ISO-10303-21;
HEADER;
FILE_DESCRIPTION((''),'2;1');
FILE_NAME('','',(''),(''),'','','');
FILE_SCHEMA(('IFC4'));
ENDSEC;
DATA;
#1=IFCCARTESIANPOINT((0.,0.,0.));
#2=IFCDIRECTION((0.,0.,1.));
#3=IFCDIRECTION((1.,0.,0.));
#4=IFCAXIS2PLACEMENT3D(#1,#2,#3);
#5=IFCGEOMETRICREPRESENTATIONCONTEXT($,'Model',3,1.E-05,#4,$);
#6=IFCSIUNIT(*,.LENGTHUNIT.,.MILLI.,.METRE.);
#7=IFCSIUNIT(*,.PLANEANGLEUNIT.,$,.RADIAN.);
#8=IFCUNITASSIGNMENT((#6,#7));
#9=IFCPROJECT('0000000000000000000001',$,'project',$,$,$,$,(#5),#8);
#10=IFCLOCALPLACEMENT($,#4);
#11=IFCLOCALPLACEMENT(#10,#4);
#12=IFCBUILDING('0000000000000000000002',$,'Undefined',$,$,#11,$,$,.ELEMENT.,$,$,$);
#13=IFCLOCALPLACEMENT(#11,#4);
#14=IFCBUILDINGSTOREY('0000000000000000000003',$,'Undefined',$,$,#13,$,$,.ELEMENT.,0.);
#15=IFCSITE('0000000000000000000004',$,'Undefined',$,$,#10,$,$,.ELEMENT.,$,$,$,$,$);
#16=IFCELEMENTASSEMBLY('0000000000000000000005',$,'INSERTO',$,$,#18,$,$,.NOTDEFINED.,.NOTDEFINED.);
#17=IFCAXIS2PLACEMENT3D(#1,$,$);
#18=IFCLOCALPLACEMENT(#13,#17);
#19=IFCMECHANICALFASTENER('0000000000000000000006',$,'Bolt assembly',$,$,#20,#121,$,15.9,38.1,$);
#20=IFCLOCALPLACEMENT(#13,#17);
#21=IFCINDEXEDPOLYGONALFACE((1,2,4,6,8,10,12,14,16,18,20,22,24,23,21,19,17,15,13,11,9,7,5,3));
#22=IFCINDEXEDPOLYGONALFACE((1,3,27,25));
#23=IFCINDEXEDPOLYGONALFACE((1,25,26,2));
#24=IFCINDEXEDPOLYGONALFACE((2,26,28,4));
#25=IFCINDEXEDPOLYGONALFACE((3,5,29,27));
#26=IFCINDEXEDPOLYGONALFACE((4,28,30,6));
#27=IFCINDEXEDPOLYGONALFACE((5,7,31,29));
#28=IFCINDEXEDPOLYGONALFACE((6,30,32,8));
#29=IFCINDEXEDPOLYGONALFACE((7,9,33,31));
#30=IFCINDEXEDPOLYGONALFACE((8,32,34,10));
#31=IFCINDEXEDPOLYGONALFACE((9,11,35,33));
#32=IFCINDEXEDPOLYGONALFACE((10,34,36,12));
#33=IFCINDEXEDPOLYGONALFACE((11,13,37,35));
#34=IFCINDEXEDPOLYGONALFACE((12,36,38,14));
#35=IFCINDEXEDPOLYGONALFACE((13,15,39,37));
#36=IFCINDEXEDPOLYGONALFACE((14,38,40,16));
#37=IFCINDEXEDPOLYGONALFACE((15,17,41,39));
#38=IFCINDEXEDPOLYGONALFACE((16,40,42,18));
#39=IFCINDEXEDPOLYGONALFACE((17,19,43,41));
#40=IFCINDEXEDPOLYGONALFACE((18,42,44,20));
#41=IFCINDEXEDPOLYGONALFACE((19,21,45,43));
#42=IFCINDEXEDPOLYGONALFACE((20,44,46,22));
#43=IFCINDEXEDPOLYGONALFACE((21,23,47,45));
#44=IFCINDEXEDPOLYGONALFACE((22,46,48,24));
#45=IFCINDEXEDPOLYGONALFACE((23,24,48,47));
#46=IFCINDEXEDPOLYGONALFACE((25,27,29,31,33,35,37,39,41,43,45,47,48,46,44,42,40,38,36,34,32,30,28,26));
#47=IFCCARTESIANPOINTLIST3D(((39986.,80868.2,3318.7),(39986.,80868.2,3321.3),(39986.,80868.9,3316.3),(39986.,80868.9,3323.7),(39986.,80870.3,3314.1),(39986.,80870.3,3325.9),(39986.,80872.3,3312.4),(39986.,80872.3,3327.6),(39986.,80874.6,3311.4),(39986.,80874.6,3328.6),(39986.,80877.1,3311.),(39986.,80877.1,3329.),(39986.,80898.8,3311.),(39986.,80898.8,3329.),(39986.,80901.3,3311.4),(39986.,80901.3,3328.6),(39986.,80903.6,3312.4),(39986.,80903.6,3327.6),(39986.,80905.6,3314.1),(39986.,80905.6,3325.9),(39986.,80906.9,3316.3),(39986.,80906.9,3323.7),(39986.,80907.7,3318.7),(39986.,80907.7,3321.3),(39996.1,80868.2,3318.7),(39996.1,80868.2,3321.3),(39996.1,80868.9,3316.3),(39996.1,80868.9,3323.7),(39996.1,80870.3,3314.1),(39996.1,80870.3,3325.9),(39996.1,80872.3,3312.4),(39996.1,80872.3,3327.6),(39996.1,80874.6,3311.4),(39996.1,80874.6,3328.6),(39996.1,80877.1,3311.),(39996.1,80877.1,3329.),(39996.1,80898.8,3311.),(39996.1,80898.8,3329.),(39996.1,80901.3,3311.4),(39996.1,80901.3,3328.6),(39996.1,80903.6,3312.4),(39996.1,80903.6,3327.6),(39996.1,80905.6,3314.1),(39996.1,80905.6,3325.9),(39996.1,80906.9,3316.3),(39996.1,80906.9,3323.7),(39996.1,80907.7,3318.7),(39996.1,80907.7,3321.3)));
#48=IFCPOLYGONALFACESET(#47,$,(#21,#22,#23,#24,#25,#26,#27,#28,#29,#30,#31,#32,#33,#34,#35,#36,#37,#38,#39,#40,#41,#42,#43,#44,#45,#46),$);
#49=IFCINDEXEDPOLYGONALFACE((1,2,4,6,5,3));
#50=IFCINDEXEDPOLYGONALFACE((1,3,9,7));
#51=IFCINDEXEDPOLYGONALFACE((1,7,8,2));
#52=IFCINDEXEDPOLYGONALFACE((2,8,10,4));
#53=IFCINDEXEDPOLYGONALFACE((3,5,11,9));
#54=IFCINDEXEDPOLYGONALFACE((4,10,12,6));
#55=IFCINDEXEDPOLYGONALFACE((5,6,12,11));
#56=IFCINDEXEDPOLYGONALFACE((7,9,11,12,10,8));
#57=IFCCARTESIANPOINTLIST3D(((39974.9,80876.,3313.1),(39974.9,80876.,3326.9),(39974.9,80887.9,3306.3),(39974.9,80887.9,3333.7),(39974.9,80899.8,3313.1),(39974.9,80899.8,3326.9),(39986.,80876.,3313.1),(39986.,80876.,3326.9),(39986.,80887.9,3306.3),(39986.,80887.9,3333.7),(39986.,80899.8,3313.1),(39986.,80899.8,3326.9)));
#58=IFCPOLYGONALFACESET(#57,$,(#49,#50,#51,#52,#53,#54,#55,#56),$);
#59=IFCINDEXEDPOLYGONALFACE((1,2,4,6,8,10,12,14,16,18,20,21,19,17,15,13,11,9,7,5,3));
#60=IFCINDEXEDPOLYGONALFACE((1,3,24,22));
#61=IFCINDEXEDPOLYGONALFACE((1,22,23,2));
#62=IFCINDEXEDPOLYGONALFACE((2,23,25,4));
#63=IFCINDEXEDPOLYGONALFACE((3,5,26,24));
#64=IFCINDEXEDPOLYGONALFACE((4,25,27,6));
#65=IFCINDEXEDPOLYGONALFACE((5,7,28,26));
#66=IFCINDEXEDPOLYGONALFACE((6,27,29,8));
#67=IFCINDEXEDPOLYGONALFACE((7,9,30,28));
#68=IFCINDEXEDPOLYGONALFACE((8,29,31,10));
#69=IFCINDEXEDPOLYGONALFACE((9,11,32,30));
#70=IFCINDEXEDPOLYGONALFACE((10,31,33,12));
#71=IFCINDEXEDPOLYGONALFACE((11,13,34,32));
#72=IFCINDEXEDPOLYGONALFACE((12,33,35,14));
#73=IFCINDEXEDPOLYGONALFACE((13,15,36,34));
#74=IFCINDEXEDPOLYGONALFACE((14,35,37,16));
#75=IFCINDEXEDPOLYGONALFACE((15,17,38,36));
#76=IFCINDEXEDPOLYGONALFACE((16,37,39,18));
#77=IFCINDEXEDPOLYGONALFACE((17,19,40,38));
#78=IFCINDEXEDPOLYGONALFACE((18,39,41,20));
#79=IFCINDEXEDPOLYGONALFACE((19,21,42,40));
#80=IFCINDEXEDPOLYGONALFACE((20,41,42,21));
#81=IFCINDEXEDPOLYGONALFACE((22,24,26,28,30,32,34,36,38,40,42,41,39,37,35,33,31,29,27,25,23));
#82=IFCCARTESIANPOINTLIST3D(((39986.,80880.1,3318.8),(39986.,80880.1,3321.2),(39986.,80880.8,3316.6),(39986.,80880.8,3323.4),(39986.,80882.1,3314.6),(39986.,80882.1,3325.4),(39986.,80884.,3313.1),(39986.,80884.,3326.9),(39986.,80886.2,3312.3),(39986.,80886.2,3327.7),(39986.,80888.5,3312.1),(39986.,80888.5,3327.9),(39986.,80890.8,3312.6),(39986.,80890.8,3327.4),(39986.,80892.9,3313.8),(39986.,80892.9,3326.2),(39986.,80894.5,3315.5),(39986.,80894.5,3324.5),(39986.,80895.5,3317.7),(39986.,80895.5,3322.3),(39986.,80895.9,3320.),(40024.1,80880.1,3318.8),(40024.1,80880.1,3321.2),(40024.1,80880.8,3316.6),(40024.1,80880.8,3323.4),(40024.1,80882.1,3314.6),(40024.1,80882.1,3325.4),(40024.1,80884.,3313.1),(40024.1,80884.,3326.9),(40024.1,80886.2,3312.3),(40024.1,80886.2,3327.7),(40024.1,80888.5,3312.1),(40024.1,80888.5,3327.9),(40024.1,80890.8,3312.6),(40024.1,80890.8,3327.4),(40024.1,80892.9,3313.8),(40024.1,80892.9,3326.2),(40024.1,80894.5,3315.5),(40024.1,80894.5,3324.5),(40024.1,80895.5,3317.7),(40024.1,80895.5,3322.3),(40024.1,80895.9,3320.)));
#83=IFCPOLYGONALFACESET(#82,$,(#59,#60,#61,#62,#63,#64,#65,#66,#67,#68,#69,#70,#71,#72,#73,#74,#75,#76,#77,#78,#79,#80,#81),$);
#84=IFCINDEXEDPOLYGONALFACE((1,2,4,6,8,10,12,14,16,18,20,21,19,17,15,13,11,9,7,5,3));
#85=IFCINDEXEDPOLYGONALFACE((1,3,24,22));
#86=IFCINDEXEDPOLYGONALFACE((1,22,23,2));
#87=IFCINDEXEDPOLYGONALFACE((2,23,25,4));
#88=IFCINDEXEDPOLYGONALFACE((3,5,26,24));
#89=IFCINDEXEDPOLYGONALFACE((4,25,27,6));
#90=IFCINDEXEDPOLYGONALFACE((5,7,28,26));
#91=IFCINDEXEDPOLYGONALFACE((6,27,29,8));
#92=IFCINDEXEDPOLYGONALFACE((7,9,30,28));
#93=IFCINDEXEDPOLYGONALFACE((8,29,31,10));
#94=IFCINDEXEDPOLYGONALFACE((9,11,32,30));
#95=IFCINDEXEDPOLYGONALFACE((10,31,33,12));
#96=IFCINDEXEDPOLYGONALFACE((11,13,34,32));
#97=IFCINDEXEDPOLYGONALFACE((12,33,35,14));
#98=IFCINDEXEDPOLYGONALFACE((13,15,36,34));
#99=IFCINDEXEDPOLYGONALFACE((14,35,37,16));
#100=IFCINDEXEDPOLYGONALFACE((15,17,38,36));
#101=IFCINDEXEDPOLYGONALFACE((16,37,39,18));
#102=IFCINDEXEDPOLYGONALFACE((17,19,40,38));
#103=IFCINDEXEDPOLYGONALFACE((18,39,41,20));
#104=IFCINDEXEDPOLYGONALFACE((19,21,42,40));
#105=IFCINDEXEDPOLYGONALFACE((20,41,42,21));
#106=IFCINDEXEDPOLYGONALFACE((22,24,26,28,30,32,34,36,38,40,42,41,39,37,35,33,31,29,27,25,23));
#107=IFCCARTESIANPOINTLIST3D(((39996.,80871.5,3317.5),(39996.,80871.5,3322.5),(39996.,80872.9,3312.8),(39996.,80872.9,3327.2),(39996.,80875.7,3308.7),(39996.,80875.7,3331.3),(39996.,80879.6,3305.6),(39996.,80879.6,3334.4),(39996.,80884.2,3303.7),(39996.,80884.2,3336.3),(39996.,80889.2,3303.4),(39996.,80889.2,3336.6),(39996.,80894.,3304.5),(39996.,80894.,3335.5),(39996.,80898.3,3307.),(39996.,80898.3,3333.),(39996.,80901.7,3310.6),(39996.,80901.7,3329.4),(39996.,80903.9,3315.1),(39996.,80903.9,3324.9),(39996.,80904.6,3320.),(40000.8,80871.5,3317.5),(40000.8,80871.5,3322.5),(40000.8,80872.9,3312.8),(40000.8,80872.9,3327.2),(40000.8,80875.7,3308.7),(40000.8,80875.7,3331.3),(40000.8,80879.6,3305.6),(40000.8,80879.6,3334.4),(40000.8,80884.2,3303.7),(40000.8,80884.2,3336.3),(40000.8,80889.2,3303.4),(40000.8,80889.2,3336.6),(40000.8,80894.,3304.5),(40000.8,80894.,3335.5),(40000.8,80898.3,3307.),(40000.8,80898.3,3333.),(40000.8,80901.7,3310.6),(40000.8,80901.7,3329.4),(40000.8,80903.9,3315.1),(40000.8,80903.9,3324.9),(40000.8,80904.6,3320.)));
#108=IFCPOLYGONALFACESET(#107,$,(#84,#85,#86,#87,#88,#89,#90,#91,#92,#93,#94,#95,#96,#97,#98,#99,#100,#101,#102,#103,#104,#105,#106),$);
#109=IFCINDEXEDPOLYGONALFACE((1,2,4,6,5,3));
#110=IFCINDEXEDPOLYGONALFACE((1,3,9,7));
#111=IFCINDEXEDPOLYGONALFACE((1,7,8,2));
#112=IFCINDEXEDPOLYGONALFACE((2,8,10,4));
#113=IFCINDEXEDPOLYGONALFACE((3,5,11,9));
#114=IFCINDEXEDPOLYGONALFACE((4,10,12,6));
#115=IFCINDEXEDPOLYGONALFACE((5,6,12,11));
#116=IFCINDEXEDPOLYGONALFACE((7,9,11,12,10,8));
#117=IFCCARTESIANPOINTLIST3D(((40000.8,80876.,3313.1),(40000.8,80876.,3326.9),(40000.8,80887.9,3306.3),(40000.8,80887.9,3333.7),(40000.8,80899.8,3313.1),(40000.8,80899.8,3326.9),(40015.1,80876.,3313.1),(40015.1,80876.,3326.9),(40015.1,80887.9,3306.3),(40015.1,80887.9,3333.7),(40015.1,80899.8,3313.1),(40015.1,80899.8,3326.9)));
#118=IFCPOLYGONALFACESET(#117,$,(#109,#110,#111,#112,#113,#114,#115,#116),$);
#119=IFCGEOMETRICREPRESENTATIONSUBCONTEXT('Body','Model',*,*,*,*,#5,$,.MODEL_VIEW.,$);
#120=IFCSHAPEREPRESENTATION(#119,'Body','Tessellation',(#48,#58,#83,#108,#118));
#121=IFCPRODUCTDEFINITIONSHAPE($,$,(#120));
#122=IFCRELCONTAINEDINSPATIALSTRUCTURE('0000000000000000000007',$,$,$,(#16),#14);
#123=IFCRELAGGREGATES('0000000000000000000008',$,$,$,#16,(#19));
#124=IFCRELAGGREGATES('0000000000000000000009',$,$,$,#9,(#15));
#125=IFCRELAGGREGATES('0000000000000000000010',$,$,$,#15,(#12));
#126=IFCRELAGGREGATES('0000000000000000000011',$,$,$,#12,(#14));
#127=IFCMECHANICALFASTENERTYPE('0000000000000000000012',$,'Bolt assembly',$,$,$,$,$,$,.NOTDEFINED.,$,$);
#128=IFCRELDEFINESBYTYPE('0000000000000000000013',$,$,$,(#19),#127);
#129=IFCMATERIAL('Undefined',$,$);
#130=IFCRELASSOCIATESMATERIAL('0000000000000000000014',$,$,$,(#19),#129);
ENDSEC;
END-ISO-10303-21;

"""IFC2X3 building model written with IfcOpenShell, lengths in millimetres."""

from ifc_helpers import new_model, si_unit, frame, frame_2d, origin_with_axes, origin_2d_with_axis, place, context, subcontext, project, spatial, polyline, circle_curve, parameter, trimmed, segment, composite_curve, circle, outline, extrude, source, transform, mapped, material, type_object, element, aggregate, save


model = new_model("IFC2X3")

# Units and contexts
model_context = context("Model", 3, precision=1e-05, world=origin_with_axes())
body_context = subcontext(model_context, "Body", "Model", "MODEL_VIEW")
ifc_project = project(units=[si_unit("LENGTHUNIT", "METRE", prefix="MILLI"), si_unit("PLANEANGLEUNIT", "RADIAN")], contexts=[model_context])

# Site, building, storey
site_placement = place(None, origin_with_axes())
site = spatial("IfcSite", under=ifc_project, at=site_placement, Name="Undefined", CompositionType="ELEMENT")
building_placement = place(site_placement, origin_with_axes())
building = spatial("IfcBuilding", under=site, at=building_placement, Name="Undefined", CompositionType="ELEMENT")
storey_placement = place(building_placement, origin_with_axes())
storey = spatial("IfcBuildingStorey", under=building, at=storey_placement, Name="Undefined", CompositionType="ELEMENT", Elevation=0.0)

# Element assembly
assembly_1_placement = place(storey_placement, origin_with_axes())
assembly_1 = element("IfcElementAssembly", 1, at=assembly_1_placement, inside=storey, Name="INSERTO", AssemblyPlace="NOTDEFINED", PredefinedType="NOTDEFINED")

# Shared definitions
ifc_material_1 = material(Name="Undefined")
mechanical_fastener_type = type_object("IfcMechanicalFastenerType", Name="Bolt assembly")

# Mechanical fastener
shared_shape_1 = source(origin_with_axes(), body_context, "Body", "SweptSolid", [
    extrude(outline(composite_curve([segment(polyline([(-10.8, 9.0), (10.8, 9.0)]), True, "CONTINUOUS"), segment(trimmed(circle_curve(frame_2d((10.8, 0.0), x_axis=(0.0, 1.0)), 9.0), [parameter(0.0)], [parameter(3.141593)], False, "PARAMETER"), True, "CONTINUOUS"), segment(polyline([(10.8, -9.0), (-10.8, -9.0)]), True, "CONTINUOUS"), segment(trimmed(circle_curve(frame_2d((-10.8, 0.0), x_axis=(0.0, -1.0)), 9.0), [parameter(0.0)], [parameter(3.141593)], False, "PARAMETER"), True, "DISCONTINUOUS")], self_intersect=False)), frame((0.0, -5.0, 0.0), z_axis=(0.0, 1.0, 0.0), x_axis=(1.0, 0.0, 0.0)), (0.0, 0.0, 1.0), 10.1),
    extrude(outline(polyline([(11.9, -6.9), (11.9, 6.9), (0.0, 13.7), (-11.9, 6.9), (-11.9, -6.9), (0.0, -13.7), (11.9, -6.9)])), frame((0.0, -16.1, 0.0), z_axis=(0.0, 1.0, 0.0), x_axis=(1.0, 0.0, 0.0)), (0.0, 0.0, 1.0), 11.1),
    extrude(circle(Radius=7.9, at=origin_2d_with_axis()), frame((0.0, -5.0, 0.0), z_axis=(0.0, 1.0, 0.0), x_axis=(1.0, 0.0, 0.0)), (0.0, 0.0, 1.0), 38.1),
    extrude(circle(Radius=16.7, at=origin_2d_with_axis()), frame((0.0, 5.0, 0.0), z_axis=(0.0, 1.0, 0.0), x_axis=(1.0, 0.0, 0.0)), (0.0, 0.0, 1.0), 4.8),
    extrude(outline(polyline([(11.9, -6.9), (11.9, 6.9), (0.0, 13.7), (-11.9, 6.9), (-11.9, -6.9), (0.0, -13.7), (11.9, -6.9)])), frame((0.0, 9.8, 0.0), z_axis=(0.0, 1.0, 0.0), x_axis=(1.0, 0.0, 0.0)), (0.0, 0.0, 1.0), 14.3),
])
mechanical_fastener_1_placement = place(assembly_1_placement, frame((39991.0, 80887.9, 3320.0), z_axis=(0.0, 0.0, -1.0), x_axis=(0.000015, 1.0, 0.0)))
mechanical_fastener_1 = element("IfcMechanicalFastener", 2, at=mechanical_fastener_1_placement, type_object=mechanical_fastener_type, material=ifc_material_1, Name="Bolt assembly", NominalDiameter=15.9, NominalLength=38.1, context=body_context, shape_type="MappedRepresentation", body=[
    mapped(shared_shape_1, transform((0.0, 0.0, 0.0))),
])
aggregate(assembly_1, [mechanical_fastener_1])

save(model, "model.ifc")
